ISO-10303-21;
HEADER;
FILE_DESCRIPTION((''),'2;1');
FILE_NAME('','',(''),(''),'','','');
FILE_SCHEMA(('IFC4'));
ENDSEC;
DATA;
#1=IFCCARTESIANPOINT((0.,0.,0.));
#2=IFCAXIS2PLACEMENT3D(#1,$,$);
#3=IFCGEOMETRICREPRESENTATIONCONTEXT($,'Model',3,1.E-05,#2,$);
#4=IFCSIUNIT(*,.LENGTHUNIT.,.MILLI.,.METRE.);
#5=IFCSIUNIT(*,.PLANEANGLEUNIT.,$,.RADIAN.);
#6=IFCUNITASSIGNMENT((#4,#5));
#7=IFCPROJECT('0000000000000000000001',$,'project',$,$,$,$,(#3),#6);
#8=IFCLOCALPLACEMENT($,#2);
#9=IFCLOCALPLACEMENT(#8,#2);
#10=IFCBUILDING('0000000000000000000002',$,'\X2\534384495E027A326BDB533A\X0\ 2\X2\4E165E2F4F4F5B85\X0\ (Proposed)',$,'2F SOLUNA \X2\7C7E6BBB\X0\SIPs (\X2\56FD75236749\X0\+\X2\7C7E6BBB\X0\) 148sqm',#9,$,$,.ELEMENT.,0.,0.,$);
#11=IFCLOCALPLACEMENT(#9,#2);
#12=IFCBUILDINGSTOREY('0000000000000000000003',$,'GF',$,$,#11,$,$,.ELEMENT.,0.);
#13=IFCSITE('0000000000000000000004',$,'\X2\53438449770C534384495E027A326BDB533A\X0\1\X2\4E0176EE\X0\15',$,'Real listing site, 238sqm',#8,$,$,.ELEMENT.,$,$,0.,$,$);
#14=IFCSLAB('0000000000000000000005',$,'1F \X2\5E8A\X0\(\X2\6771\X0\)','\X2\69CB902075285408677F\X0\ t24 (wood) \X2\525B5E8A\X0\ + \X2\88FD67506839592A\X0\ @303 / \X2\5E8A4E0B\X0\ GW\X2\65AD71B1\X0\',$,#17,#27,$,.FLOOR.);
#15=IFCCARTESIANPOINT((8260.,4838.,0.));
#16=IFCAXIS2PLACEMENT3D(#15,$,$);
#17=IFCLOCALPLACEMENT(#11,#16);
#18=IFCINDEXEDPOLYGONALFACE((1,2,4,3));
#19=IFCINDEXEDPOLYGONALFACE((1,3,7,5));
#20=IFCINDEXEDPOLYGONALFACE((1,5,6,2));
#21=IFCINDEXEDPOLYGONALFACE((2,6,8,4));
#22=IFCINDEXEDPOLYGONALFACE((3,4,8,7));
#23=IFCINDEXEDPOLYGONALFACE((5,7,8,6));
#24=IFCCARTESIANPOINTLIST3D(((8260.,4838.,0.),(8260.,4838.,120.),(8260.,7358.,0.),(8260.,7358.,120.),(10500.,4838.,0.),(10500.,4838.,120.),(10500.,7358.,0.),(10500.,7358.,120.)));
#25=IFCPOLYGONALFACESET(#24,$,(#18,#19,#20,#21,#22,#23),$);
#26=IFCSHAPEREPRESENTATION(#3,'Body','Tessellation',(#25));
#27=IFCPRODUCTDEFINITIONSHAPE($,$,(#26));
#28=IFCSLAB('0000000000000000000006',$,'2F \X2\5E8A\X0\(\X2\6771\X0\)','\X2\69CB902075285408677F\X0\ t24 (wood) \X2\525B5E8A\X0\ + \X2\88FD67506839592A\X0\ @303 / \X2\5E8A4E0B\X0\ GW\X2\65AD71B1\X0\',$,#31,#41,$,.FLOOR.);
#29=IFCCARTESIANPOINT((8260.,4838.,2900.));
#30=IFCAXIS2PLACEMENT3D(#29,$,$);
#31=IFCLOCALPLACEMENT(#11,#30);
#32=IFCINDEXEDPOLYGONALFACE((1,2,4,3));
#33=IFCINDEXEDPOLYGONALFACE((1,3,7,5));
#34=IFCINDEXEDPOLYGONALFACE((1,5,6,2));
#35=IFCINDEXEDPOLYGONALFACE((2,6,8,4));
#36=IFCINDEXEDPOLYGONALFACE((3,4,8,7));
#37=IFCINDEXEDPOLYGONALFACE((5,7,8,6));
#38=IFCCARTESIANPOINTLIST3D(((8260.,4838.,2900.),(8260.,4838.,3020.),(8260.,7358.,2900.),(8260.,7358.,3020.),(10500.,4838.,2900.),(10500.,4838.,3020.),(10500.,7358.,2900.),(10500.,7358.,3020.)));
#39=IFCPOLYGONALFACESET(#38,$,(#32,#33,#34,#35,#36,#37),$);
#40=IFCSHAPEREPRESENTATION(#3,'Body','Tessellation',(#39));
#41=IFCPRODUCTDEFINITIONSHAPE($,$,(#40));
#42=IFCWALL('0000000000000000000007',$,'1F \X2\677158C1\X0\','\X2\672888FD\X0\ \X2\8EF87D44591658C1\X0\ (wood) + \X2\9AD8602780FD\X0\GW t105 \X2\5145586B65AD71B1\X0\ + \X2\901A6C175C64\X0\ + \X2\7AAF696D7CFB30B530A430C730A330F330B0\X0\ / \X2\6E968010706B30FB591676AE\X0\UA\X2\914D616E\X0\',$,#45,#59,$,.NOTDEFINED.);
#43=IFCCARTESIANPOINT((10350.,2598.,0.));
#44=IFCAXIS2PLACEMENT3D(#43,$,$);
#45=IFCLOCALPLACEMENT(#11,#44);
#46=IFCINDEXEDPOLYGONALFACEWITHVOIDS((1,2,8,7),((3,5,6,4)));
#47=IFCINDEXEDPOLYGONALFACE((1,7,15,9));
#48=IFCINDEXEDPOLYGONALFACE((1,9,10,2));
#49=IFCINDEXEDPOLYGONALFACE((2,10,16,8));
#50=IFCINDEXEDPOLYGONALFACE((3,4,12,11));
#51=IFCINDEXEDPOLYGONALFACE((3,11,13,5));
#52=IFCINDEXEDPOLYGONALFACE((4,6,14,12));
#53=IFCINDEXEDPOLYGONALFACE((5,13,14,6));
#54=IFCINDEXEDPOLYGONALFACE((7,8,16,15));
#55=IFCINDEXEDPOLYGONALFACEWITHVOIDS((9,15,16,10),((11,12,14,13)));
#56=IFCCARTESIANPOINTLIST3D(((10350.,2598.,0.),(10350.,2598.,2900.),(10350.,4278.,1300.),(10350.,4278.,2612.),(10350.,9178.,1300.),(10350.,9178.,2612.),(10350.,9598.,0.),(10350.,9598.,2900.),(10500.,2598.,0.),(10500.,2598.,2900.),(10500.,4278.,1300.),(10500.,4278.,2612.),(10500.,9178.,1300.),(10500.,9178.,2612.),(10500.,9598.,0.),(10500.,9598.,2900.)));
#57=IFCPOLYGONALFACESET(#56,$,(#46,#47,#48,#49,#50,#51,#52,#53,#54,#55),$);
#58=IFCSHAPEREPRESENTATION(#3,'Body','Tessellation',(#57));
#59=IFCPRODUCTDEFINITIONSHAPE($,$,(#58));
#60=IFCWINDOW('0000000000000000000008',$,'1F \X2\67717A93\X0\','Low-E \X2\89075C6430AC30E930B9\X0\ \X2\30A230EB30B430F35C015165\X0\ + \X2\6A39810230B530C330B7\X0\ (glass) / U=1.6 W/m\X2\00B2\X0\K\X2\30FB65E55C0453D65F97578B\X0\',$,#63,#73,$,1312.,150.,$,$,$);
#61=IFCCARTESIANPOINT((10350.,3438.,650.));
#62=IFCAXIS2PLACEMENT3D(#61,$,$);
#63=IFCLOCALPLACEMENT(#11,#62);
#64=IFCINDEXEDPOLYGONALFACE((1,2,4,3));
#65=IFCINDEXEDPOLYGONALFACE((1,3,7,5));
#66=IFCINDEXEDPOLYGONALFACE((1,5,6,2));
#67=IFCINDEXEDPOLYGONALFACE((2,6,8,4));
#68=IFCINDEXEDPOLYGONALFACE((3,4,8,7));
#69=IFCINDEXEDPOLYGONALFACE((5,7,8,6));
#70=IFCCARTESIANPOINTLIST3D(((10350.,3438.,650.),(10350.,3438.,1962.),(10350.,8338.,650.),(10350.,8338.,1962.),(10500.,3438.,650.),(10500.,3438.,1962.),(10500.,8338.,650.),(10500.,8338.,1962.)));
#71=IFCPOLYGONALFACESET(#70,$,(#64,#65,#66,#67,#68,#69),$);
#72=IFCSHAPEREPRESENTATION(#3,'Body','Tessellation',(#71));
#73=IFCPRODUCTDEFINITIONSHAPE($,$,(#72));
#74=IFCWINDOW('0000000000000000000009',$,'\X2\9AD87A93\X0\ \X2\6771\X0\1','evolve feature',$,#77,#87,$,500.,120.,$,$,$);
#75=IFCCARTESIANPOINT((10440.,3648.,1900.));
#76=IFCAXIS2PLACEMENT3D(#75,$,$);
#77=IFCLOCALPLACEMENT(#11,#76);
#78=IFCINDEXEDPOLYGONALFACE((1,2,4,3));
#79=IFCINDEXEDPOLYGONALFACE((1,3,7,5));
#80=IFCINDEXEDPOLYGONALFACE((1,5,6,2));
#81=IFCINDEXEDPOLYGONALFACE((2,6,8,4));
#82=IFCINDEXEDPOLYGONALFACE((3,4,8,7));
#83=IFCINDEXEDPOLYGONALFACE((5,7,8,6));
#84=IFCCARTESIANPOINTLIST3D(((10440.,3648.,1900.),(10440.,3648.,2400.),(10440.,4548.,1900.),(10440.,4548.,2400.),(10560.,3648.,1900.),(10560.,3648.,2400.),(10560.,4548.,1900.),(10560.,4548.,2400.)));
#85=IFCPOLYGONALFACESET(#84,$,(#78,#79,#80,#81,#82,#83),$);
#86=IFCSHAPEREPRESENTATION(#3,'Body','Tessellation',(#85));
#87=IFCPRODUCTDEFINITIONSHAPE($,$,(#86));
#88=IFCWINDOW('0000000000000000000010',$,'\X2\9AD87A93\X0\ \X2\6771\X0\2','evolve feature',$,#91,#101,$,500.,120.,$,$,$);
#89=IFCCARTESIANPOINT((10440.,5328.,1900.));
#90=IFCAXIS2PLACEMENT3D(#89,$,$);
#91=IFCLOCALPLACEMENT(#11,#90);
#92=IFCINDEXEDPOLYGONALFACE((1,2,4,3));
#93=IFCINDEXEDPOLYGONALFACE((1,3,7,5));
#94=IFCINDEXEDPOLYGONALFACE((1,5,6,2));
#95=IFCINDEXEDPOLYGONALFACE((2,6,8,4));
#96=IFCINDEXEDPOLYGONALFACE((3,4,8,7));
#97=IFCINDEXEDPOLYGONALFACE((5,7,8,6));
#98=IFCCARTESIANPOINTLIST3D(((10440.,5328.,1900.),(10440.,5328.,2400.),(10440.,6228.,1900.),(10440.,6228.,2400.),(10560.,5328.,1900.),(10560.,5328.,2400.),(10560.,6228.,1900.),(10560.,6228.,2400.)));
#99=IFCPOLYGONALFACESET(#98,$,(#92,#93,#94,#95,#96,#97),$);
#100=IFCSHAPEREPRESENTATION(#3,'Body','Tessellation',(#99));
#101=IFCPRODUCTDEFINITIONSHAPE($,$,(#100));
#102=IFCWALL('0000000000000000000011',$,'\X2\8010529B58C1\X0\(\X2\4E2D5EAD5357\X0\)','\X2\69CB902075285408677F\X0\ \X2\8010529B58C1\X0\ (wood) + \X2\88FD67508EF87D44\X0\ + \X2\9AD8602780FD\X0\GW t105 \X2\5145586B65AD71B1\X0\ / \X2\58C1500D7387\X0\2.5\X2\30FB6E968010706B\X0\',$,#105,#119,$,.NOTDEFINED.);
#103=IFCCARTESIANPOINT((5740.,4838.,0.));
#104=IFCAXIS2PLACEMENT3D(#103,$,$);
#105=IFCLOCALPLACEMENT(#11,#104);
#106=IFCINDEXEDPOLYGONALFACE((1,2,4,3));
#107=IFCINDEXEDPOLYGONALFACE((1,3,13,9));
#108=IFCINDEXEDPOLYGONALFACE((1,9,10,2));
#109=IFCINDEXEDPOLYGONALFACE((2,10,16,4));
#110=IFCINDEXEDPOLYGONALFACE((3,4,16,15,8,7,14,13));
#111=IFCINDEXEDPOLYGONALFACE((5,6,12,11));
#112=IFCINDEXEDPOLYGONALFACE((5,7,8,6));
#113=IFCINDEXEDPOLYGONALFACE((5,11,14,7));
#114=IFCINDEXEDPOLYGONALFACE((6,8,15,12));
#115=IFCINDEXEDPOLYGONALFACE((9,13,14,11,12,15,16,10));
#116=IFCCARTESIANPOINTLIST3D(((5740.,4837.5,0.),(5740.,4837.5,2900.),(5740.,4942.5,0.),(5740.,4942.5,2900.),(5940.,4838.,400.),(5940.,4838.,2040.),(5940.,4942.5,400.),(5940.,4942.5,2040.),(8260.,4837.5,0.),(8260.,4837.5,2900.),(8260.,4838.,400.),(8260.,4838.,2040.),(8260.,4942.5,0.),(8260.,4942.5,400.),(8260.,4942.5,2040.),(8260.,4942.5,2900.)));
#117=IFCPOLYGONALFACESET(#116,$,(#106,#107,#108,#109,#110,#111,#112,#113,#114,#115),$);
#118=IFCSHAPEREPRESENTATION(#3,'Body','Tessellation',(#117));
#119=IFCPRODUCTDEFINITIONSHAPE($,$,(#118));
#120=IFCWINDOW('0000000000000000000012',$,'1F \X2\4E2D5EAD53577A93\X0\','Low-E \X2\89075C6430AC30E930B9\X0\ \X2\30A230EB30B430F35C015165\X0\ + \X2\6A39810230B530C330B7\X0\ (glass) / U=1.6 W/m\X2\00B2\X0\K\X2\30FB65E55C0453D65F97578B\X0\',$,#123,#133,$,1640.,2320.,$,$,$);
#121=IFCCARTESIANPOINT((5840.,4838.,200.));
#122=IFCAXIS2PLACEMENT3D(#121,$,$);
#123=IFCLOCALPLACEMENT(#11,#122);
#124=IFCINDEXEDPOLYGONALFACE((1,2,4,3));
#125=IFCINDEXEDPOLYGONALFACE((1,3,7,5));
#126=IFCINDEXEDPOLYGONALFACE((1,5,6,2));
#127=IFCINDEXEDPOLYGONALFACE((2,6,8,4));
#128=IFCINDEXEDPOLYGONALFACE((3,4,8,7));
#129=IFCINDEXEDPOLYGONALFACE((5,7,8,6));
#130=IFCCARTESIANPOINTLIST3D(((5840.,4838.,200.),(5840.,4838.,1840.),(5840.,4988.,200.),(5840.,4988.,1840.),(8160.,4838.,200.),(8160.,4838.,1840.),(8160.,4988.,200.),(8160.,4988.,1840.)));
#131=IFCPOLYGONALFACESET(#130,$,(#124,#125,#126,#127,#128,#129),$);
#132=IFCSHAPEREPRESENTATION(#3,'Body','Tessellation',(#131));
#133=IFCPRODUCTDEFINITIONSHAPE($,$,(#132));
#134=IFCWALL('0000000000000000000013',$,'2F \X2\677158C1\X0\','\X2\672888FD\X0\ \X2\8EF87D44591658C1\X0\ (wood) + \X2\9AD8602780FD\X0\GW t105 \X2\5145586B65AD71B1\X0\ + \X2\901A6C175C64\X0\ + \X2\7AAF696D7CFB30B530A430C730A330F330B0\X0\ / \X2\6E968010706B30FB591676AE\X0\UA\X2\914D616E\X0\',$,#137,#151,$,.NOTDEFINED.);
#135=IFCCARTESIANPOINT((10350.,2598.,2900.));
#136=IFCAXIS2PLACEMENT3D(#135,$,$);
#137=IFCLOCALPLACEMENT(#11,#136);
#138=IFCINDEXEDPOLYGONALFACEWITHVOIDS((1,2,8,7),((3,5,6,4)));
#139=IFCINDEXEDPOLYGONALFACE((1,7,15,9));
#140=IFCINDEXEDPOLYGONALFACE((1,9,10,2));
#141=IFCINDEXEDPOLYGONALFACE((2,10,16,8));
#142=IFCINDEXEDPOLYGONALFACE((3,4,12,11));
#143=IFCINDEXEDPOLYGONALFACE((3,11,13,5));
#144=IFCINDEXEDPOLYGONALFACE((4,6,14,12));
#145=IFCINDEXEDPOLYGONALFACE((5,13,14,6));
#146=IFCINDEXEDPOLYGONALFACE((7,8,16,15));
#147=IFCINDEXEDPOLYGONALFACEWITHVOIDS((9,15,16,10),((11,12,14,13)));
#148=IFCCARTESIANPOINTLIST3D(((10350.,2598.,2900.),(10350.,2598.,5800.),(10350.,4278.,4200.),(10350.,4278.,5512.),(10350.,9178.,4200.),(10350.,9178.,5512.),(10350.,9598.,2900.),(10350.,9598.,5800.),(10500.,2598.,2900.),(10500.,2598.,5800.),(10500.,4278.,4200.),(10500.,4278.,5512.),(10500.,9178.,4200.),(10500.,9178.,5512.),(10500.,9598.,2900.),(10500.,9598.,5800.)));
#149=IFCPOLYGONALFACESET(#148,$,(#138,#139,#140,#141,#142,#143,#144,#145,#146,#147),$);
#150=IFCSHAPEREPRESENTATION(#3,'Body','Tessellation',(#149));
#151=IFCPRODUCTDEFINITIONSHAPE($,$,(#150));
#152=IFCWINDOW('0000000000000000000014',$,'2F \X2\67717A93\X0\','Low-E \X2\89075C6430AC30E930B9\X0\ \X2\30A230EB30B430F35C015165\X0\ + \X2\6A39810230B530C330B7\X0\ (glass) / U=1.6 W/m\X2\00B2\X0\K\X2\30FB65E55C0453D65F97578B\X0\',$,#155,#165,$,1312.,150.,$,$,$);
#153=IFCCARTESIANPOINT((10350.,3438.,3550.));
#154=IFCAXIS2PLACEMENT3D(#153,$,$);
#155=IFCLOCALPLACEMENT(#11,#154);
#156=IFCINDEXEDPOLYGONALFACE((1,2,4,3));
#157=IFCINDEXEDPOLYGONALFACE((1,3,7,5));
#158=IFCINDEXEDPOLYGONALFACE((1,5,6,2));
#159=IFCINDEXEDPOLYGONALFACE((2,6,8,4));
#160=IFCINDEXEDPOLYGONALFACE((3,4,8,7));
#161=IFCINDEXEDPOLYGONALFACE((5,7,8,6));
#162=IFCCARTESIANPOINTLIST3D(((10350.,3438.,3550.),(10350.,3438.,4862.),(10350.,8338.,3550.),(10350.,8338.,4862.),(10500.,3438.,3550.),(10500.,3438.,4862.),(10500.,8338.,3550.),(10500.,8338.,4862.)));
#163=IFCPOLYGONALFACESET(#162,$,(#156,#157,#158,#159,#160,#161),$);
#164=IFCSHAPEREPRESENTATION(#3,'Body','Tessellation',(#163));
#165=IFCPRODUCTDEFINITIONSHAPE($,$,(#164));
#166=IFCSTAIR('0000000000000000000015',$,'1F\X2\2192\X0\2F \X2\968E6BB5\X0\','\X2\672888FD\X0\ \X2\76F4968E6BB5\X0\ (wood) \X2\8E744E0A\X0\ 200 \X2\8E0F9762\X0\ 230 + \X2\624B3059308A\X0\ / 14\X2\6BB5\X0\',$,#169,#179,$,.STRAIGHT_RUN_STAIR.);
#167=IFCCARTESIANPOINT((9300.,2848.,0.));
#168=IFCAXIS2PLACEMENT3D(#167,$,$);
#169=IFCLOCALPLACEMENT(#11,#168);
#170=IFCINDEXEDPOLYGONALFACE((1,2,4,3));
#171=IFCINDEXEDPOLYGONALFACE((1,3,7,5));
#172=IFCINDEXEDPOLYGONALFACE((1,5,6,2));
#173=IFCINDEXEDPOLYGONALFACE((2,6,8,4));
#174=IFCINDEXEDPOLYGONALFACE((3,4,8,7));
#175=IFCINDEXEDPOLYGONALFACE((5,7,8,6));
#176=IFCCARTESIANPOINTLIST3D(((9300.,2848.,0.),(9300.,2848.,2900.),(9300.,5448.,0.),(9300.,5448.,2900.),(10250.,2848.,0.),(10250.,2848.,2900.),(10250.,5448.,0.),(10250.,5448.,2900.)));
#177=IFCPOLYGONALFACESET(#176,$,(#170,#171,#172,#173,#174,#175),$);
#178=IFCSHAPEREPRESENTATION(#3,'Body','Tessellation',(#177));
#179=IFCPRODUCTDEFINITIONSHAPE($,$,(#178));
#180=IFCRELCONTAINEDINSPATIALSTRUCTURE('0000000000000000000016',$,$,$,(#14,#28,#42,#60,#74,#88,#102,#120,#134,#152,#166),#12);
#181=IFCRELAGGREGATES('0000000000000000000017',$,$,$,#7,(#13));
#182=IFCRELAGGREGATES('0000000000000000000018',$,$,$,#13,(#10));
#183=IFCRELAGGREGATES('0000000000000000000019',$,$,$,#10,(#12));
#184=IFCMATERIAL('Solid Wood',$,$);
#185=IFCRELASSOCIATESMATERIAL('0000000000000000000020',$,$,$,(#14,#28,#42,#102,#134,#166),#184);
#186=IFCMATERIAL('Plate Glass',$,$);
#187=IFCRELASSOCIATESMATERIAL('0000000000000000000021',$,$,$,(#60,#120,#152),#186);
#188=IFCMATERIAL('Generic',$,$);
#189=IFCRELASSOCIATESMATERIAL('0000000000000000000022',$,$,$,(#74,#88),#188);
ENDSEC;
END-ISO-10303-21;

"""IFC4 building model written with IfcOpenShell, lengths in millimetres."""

from ifc_helpers import new_model, si_unit, frame, frame_2d, origin, place, context, project, spatial, rectangle, extrude, material, element, fill, save


model = new_model("IFC4")

# Units and contexts
model_context = context("Model", 3, precision=1e-05, world=origin())
ifc_project = project(units=[si_unit("LENGTHUNIT", "METRE", prefix="MILLI"), si_unit("PLANEANGLEUNIT", "RADIAN")], contexts=[model_context])

# Site, building, storey
site_placement = place(None, origin())
site = spatial("IfcSite", under=ifc_project, at=site_placement, Name="千葉県千葉市稲毛区1丁目15", ObjectType="Real listing site, 238sqm", CompositionType="ELEMENT", RefElevation=0.0)
building_placement = place(site_placement, origin())
building = spatial("IfcBuilding", under=site, at=building_placement, Name="千葉市稲毛区 2世帯住宅 (Proposed)", ObjectType="2F SOLUNA 籾殻SIPs (国産杉+籾殻) 148sqm", CompositionType="ELEMENT", ElevationOfRefHeight=0.0, ElevationOfTerrain=0.0)
storey_placement = place(building_placement, origin())
storey = spatial("IfcBuildingStorey", under=building, at=storey_placement, Name="GF", CompositionType="ELEMENT", Elevation=0.0)

# Slabs
ifc_material_1 = material(Name="Solid Wood")
slab_1_placement = place(storey_placement, frame((8260.0, 4838.0, 0.0)))
element("IfcSlab", 1, at=slab_1_placement, inside=storey, material=ifc_material_1, Name="1F 床(東)", Description="構造用合板 t24 (wood) 剛床 + 製材根太 @303 / 床下 GW断熱", PredefinedType="FLOOR", context=model_context, shape_type="SweptSolid", body=[
    extrude(rectangle(XDim=2240.0, YDim=2520.0, at=frame_2d((1120.0, 1260.0))), frame((8260.0, 4838.0, 0.0)), (0.0, 0.0, 1.0), 120.0),
])
slab_2_placement = place(storey_placement, frame((8260.0, 4838.0, 2900.0)))
element("IfcSlab", 2, at=slab_2_placement, inside=storey, material=ifc_material_1, Name="2F 床(東)", Description="構造用合板 t24 (wood) 剛床 + 製材根太 @303 / 床下 GW断熱", PredefinedType="FLOOR", context=model_context, shape_type="SweptSolid", body=[
    extrude(rectangle(XDim=2240.0, YDim=2520.0, at=frame_2d((1120.0, 1260.0))), frame((8260.0, 4838.0, 2900.0)), (0.0, 0.0, 1.0), 120.0),
])

# Wall, openings, windows
wall_1_placement = place(storey_placement, frame((10350.0, 2598.0, 0.0)))
wall_1 = element("IfcWall", 3, at=wall_1_placement, inside=storey, material=ifc_material_1, Name="1F 東壁", Description="木製 軸組外壁 (wood) + 高性能GW t105 充填断熱 + 通気層 + 窯業系サイディング / 準耐火・外皮UA配慮", PredefinedType="NOTDEFINED", context=model_context, shape_type="SweptSolid", body=[
    extrude(rectangle(XDim=150.0, YDim=7000.0, at=frame_2d((75.0, 3500.0))), frame((10350.0, 2598.0, 0.0)), (0.0, 0.0, 1.0), 2900.0),
])
opening_1_placement = place(storey_placement, frame((10350.0, 3438.0, 650.0)))
opening_1 = element("IfcOpeningElement", 4, at=opening_1_placement, cuts=wall_1, PredefinedType="NOTDEFINED", context=model_context, shape_type="SweptSolid", body=[
    extrude(rectangle(XDim=150.0, YDim=4900.0, at=frame_2d((75.0, 2450.0))), frame((10350.0, 3438.0, 650.0)), (0.0, 0.0, 1.0), 1312.0),
])
opening_2_placement = place(storey_placement, frame((10440.0, 3648.0, 1900.0)))
opening_2 = element("IfcOpeningElement", 5, at=opening_2_placement, cuts=wall_1, PredefinedType="NOTDEFINED", context=model_context, shape_type="SweptSolid", body=[
    extrude(rectangle(XDim=120.0, YDim=900.0, at=frame_2d((60.0, 450.0))), frame((10440.0, 3648.0, 1900.0)), (0.0, 0.0, 1.0), 500.0),
])
opening_3_placement = place(storey_placement, frame((10440.0, 5328.0, 1900.0)))
opening_3 = element("IfcOpeningElement", 6, at=opening_3_placement, cuts=wall_1, PredefinedType="NOTDEFINED", context=model_context, shape_type="SweptSolid", body=[
    extrude(rectangle(XDim=120.0, YDim=900.0, at=frame_2d((60.0, 450.0))), frame((10440.0, 5328.0, 1900.0)), (0.0, 0.0, 1.0), 500.0),
])
ifc_material_2 = material(Name="Plate Glass")
window_1_placement = place(storey_placement, frame((10350.0, 3438.0, 650.0)))
window_1 = element("IfcWindow", 7, at=window_1_placement, inside=storey, material=ifc_material_2, Name="1F 東窓", Description="Low-E 複層ガラス アルゴン封入 + 樹脂サッシ (glass) / U=1.6 W/m²K・日射取得型", OverallHeight=1312.0, OverallWidth=150.0, context=model_context, shape_type="SweptSolid", body=[
    extrude(rectangle(XDim=150.0, YDim=4900.0, at=frame_2d((75.0, 2450.0))), frame((10350.0, 3438.0, 650.0)), (0.0, 0.0, 1.0), 1312.0),
])
fill(opening_1, window_1)
ifc_material_3 = material(Name="Generic")
window_2_placement = place(storey_placement, frame((10440.0, 3648.0, 1900.0)))
window_2 = element("IfcWindow", 8, at=window_2_placement, inside=storey, material=ifc_material_3, Name="高窓 東1", Description="evolve feature", OverallHeight=500.0, OverallWidth=120.0, context=model_context, shape_type="SweptSolid", body=[
    extrude(rectangle(XDim=120.0, YDim=900.0, at=frame_2d((60.0, 450.0))), frame((10440.0, 3648.0, 1900.0)), (0.0, 0.0, 1.0), 500.0),
])
fill(opening_2, window_2)
window_3_placement = place(storey_placement, frame((10440.0, 5328.0, 1900.0)))
window_3 = element("IfcWindow", 9, at=window_3_placement, inside=storey, material=ifc_material_3, Name="高窓 東2", Description="evolve feature", OverallHeight=500.0, OverallWidth=120.0, context=model_context, shape_type="SweptSolid", body=[
    extrude(rectangle(XDim=120.0, YDim=900.0, at=frame_2d((60.0, 450.0))), frame((10440.0, 5328.0, 1900.0)), (0.0, 0.0, 1.0), 500.0),
])
fill(opening_3, window_3)

# Wall, opening, window
wall_2_placement = place(storey_placement, frame((5740.0, 4838.0, 0.0)))
wall_2 = element("IfcWall", 10, at=wall_2_placement, inside=storey, material=ifc_material_1, Name="耐力壁(中庭南)", Description="構造用合板 耐力壁 (wood) + 製材軸組 + 高性能GW t105 充填断熱 / 壁倍率2.5・準耐火", PredefinedType="NOTDEFINED", context=model_context, shape_type="SweptSolid", body=[
    extrude(rectangle(XDim=2520.0, YDim=105.0, at=frame_2d((1260.0, 52.0))), frame((5740.0, 4838.0, 0.0)), (0.0, 0.0, 1.0), 2900.0),
])
opening_4_placement = place(storey_placement, frame((5840.0, 4838.0, 200.0)))
opening_4 = element("IfcOpeningElement", 11, at=opening_4_placement, cuts=wall_2, PredefinedType="NOTDEFINED", context=model_context, shape_type="SweptSolid", body=[
    extrude(rectangle(XDim=2320.0, YDim=150.0, at=frame_2d((1160.0, 75.0))), frame((5840.0, 4838.0, 200.0)), (0.0, 0.0, 1.0), 1640.0),
])
window_4_placement = place(storey_placement, frame((5840.0, 4838.0, 200.0)))
window_4 = element("IfcWindow", 12, at=window_4_placement, inside=storey, material=ifc_material_2, Name="1F 中庭南窓", Description="Low-E 複層ガラス アルゴン封入 + 樹脂サッシ (glass) / U=1.6 W/m²K・日射取得型", OverallHeight=1640.0, OverallWidth=2320.0, context=model_context, shape_type="SweptSolid", body=[
    extrude(rectangle(XDim=2320.0, YDim=150.0, at=frame_2d((1160.0, 75.0))), frame((5840.0, 4838.0, 200.0)), (0.0, 0.0, 1.0), 1640.0),
])
fill(opening_4, window_4)

# Wall, opening, window
wall_3_placement = place(storey_placement, frame((10350.0, 2598.0, 2900.0)))
wall_3 = element("IfcWall", 13, at=wall_3_placement, inside=storey, material=ifc_material_1, Name="2F 東壁", Description="木製 軸組外壁 (wood) + 高性能GW t105 充填断熱 + 通気層 + 窯業系サイディング / 準耐火・外皮UA配慮", PredefinedType="NOTDEFINED", context=model_context, shape_type="SweptSolid", body=[
    extrude(rectangle(XDim=150.0, YDim=7000.0, at=frame_2d((75.0, 3500.0))), frame((10350.0, 2598.0, 2900.0)), (0.0, 0.0, 1.0), 2900.0),
])
opening_5_placement = place(storey_placement, frame((10350.0, 3438.0, 3550.0)))
opening_5 = element("IfcOpeningElement", 14, at=opening_5_placement, cuts=wall_3, PredefinedType="NOTDEFINED", context=model_context, shape_type="SweptSolid", body=[
    extrude(rectangle(XDim=150.0, YDim=4900.0, at=frame_2d((75.0, 2450.0))), frame((10350.0, 3438.0, 3550.0)), (0.0, 0.0, 1.0), 1312.0),
])
window_5_placement = place(storey_placement, frame((10350.0, 3438.0, 3550.0)))
window_5 = element("IfcWindow", 15, at=window_5_placement, inside=storey, material=ifc_material_2, Name="2F 東窓", Description="Low-E 複層ガラス アルゴン封入 + 樹脂サッシ (glass) / U=1.6 W/m²K・日射取得型", OverallHeight=1312.0, OverallWidth=150.0, context=model_context, shape_type="SweptSolid", body=[
    extrude(rectangle(XDim=150.0, YDim=4900.0, at=frame_2d((75.0, 2450.0))), frame((10350.0, 3438.0, 3550.0)), (0.0, 0.0, 1.0), 1312.0),
])
fill(opening_5, window_5)

# Stair
stair_placement = place(storey_placement, frame((9300.0, 2848.0, 0.0)))
element("IfcStair", 16, at=stair_placement, inside=storey, material=ifc_material_1, Name="1F→2F 階段", Description="木製 直階段 (wood) 蹴上 200 踏面 230 + 手すり / 14段", PredefinedType="STRAIGHT_RUN_STAIR", context=model_context, shape_type="SweptSolid", body=[
    extrude(rectangle(XDim=950.0, YDim=2600.0, at=frame_2d((475.0, 1300.0))), frame((9300.0, 2848.0, 0.0)), (0.0, 0.0, 1.0), 2900.0),
])

save(model, "model.ifc")
